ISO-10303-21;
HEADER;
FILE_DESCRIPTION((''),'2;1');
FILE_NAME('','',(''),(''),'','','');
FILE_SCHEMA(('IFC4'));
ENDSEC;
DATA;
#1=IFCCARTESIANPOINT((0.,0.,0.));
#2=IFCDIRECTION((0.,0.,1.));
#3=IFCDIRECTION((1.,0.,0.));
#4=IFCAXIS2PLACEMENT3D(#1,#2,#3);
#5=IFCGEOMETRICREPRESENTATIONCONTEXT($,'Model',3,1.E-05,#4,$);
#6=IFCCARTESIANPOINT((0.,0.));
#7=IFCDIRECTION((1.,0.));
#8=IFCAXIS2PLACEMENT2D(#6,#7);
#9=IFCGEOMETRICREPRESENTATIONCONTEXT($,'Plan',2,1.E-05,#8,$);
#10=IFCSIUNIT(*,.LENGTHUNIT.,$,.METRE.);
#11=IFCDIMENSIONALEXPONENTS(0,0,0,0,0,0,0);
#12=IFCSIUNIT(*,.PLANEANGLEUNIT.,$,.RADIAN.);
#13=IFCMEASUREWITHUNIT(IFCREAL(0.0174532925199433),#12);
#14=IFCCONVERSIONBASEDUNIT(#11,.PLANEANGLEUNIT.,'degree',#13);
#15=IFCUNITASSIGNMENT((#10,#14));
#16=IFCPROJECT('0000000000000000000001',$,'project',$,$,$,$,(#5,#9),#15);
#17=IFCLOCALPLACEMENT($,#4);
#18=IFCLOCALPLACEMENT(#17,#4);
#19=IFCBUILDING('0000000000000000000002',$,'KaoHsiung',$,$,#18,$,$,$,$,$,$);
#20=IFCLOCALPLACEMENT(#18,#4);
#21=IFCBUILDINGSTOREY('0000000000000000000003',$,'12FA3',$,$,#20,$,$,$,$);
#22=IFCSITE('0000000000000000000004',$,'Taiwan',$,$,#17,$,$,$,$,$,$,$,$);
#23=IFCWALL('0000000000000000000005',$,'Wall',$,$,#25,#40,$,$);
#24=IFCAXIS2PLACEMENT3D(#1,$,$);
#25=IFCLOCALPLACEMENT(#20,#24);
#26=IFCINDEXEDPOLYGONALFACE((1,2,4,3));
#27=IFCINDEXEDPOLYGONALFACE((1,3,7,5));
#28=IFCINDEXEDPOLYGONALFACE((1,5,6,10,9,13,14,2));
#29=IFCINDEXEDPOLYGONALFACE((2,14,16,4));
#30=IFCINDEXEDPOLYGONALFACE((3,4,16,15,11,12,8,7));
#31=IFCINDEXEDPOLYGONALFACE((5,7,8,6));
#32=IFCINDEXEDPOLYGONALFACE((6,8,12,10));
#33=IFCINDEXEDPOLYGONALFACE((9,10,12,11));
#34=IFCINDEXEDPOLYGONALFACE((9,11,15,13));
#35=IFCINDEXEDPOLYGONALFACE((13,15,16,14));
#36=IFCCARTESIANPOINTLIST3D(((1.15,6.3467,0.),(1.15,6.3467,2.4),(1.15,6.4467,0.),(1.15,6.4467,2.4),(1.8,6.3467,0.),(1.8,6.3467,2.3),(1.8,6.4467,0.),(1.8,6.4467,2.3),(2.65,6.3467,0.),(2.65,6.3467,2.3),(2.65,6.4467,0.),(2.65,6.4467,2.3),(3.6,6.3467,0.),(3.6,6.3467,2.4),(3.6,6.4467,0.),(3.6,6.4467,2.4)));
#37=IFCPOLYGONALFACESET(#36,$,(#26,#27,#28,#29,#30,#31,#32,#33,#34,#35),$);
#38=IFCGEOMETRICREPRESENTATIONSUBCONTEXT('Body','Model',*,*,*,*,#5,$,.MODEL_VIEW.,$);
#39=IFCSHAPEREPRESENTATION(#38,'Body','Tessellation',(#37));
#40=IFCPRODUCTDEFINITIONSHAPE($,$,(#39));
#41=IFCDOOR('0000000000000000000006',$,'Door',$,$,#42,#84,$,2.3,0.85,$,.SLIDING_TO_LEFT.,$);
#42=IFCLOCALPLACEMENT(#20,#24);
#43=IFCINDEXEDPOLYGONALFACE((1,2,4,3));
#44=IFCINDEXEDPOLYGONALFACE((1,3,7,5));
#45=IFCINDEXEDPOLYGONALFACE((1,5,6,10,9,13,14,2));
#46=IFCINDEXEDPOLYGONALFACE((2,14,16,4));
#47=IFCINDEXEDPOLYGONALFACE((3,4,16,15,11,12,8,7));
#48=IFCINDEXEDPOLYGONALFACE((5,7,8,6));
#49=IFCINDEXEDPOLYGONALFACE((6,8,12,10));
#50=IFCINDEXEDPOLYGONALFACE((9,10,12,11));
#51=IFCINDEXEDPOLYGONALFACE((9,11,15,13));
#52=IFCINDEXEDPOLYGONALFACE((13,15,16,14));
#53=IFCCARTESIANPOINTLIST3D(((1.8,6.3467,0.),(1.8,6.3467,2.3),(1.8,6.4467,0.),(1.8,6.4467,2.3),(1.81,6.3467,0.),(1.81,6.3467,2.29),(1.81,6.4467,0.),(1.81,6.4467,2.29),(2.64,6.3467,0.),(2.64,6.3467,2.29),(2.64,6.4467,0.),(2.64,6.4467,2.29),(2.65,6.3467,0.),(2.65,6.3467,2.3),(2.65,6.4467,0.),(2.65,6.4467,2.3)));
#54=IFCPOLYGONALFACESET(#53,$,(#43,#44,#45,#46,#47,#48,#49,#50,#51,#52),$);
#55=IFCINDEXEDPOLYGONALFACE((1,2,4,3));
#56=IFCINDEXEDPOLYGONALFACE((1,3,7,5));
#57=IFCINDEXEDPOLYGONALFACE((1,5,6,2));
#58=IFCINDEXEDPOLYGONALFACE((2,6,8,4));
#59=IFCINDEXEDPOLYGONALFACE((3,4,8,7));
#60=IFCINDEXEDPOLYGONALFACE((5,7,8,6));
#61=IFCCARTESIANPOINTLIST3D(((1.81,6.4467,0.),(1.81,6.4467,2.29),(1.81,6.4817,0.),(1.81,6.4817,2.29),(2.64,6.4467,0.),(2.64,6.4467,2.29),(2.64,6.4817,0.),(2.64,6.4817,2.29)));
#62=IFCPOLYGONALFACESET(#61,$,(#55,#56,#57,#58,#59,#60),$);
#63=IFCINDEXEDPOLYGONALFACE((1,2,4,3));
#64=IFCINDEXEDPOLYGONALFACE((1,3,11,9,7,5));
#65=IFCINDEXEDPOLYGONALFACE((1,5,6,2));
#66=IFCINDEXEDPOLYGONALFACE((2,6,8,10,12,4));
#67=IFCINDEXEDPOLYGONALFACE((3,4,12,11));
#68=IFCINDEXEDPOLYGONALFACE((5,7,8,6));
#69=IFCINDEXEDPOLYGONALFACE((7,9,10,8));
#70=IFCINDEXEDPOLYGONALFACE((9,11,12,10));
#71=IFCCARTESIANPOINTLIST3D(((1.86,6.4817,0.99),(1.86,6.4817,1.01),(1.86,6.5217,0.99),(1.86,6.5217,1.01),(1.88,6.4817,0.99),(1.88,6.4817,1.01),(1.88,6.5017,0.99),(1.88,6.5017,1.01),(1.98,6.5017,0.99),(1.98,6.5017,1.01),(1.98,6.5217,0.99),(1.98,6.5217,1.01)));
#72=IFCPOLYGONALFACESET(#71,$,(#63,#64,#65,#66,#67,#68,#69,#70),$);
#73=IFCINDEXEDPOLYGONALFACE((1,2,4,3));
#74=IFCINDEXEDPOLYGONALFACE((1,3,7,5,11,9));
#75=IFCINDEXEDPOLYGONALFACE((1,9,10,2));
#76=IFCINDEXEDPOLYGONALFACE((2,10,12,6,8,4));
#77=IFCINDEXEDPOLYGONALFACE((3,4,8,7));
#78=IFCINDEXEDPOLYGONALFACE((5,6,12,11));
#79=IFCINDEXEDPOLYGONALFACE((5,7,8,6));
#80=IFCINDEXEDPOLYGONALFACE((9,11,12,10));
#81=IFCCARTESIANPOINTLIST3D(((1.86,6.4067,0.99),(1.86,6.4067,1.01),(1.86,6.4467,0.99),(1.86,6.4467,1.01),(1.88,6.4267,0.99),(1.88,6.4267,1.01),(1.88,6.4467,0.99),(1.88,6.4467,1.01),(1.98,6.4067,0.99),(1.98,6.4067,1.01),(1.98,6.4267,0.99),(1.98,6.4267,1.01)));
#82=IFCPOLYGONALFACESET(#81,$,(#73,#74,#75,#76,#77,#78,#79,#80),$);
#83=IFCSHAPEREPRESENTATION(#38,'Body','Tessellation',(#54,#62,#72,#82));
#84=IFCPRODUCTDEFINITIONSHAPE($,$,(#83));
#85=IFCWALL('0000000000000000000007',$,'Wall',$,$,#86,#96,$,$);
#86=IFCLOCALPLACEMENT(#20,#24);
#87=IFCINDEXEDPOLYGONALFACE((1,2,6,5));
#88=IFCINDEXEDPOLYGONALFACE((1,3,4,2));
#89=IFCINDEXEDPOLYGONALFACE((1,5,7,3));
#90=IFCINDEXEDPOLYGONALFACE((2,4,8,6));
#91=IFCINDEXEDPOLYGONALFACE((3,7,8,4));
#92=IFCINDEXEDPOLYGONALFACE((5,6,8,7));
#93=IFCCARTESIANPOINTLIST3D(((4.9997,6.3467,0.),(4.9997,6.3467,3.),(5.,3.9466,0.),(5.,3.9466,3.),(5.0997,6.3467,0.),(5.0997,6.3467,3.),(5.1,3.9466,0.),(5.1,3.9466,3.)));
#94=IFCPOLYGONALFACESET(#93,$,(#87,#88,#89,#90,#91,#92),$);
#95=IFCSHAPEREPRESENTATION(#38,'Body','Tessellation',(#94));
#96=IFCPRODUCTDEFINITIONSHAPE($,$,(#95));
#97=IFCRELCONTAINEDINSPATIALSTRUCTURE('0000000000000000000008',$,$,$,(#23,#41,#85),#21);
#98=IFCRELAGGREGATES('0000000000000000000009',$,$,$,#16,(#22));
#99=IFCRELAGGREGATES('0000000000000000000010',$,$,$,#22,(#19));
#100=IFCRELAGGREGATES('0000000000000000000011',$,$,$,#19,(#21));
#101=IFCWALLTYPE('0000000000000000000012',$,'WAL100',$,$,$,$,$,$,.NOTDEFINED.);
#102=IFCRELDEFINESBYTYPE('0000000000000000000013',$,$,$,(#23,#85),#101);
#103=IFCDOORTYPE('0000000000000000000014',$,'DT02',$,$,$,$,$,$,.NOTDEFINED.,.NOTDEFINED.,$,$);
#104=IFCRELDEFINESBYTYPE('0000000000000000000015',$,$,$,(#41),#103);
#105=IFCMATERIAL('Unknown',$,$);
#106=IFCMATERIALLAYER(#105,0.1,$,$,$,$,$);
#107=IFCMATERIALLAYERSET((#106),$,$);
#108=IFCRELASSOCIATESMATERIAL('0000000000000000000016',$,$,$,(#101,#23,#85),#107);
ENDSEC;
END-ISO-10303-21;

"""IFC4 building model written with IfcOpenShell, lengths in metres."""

from ifc_helpers import new_model, entity, si_unit, converted_unit, frame, origin_with_axes, origin_2d_with_axis, place, context, subcontext, project, spatial, line, indexed_curve, outline, extrude, shape, source, transform, mapped, material, layer, layer_set, layer_usage, type_object, type_shapes, element, fill, save


model = new_model("IFC4")

# Units and contexts
model_context = context("Model", 3, precision=1e-05, world=origin_with_axes())
plan_context = context("Plan", 2, precision=1e-05, world=origin_2d_with_axis())
body_context_1 = subcontext(model_context, "Body", "Model", "MODEL_VIEW")
body_context_2 = subcontext(plan_context, "Body", "Plan", "PLAN_VIEW")
ifc_project = project(units=[si_unit("LENGTHUNIT", "METRE"), converted_unit("PLANEANGLEUNIT", "degree", entity("IfcReal", 0.0174532925199433), si_unit("PLANEANGLEUNIT", "RADIAN"), dimensions=[0, 0, 0, 0, 0, 0, 0])], contexts=[model_context, plan_context])

# Site, building, storey
site_placement = place(None, origin_with_axes())
site = spatial("IfcSite", under=ifc_project, at=site_placement, Name="Taiwan")
building_placement = place(site_placement, origin_with_axes())
building = spatial("IfcBuilding", under=site, at=building_placement, Name="KaoHsiung")
storey_placement = place(building_placement, origin_with_axes())
storey = spatial("IfcBuildingStorey", under=building, at=storey_placement, Name="12FA3")

# Shared definitions
ifc_material = material(Name="Unknown")

# Shared definitions
ifc_layer_1 = layer(ifc_material, 0.1)
ifc_layer_set_1 = layer_set([ifc_layer_1])
wall_type_1 = type_object("IfcWallType", Name="WAL100", PredefinedType="NOTDEFINED", material=ifc_layer_set_1)

# Wall, opening, door
ifc_layer_usage_1 = layer_usage(ifc_layer_set_1, "AXIS2", "POSITIVE", 0.0)
wall_1_placement = place(storey_placement, frame((3.6, 6.4467, 0.0), z_axis=(0.0, 0.0, 1.0), x_axis=(-1.0, 0.0, 0.0)))
wall_1 = element("IfcWall", 1, at=wall_1_placement, inside=storey, type_object=wall_type_1, material=ifc_layer_usage_1, Name="Wall", context=body_context_1, shape_type="SweptSolid", body=[
    extrude(outline(indexed_curve([(0.0, 0.0), (0.0, 0.1), (2.45, 0.1), (2.45, 0.0)], segments=[line(1, 2, 3, 4, 1)])), origin_with_axes(), (0.0, 0.0, 1.0), 2.4),
])
shared_shape_1 = source(origin_with_axes(), body_context_1, "Body", "SweptSolid", [
    extrude(outline(indexed_curve([(0.0, 0.0), (0.85, 0.0), (0.85, 2.3), (0.0, 2.3)], segments=[line(1, 2, 3, 4, 1)])), frame((0.0, -0.6, 0.0), z_axis=(0.0, -1.0, 0.0), x_axis=(1.0, 0.0, 0.0)), (0.0, 0.0, -1.0), 1.2),
])
opening_1_placement = place(wall_1_placement, frame((0.95, 0.0, 0.0), z_axis=(0.0, 0.0, 1.0), x_axis=(1.0, 0.0, 0.0)))
opening_1 = element("IfcOpeningElement", 2, at=opening_1_placement, cuts=wall_1, PredefinedType="OPENING", context=body_context_1, shape_type="MappedRepresentation", body=[
    mapped(shared_shape_1, transform((0.0, 0.0, 0.0), x_axis=(1.0, 0.0, 0.0), y_axis=(0.0, 1.0, 0.0), z_axis=(0.0, 0.0, 1.0), scale=1.0)),
])
door_type_1 = type_object("IfcDoorType", Name="DT02", OperationType="NOTDEFINED", PredefinedType="NOTDEFINED")
shared_shape_2 = source(origin_with_axes(), body_context_1, "Body", "SweptSolid", [
    extrude(outline(indexed_curve([(0.0, 0.0), (0.0, 2.3), (0.85, 2.3), (0.85, 0.0), (0.84, 0.0), (0.84, 2.29), (0.01, 2.29), (0.01, 0.0)], segments=[line(1, 2, 3, 4, 5, 6, 7, 8, 1)])), frame((0.0, 0.0, 0.0), z_axis=(0.0, -1.0, 0.0), x_axis=(1.0, 0.0, 0.0)), (0.0, 0.0, -1.0), 0.1),
    extrude(outline(indexed_curve([(0.0, 0.0), (0.83, 0.0), (0.83, 0.035), (0.0, 0.035)], segments=[line(1, 2, 3, 4, 1)])), frame((0.01, -0.035, 0.0), z_axis=(0.0, 0.0, 1.0), x_axis=(1.0, 0.0, 0.0)), (0.0, 0.0, 1.0), 2.29),
    extrude(outline(indexed_curve([(0.0, 0.0), (0.0, -0.04), (-0.12, -0.04), (-0.12, -0.02), (-0.02, -0.02), (-0.02, 0.0)], segments=[line(1, 2, 3, 4, 5, 6, 1)])), frame((0.79, -0.035, 0.99), z_axis=(0.0, 0.0, 1.0), x_axis=(1.0, 0.0, 0.0)), (0.0, 0.0, 1.0), 0.02),
    extrude(outline(indexed_curve([(0.0, 0.0), (0.0, 0.04), (-0.12, 0.04), (-0.12, 0.02), (-0.02, 0.02), (-0.02, 0.0)], segments=[line(1, 2, 3, 4, 5, 6, 1)])), frame((0.79, 0.0, 0.99), z_axis=(0.0, 0.0, 1.0), x_axis=(1.0, 0.0, 0.0)), (0.0, 0.0, 1.0), 0.02),
])
shared_shape_3 = source(origin_with_axes(), body_context_2, "Body", "Curve2D", [
    entity("IfcIndexedPolyCurve", entity("IfcCartesianPointList2D", [[0.0, 0.0], [0.01, 0.0], [0.01, 0.1], [0.0, 0.1]]), [entity("IfcLineIndex", [1, 2, 3, 4, 1])]),
    entity("IfcIndexedPolyCurve", entity("IfcCartesianPointList2D", [[0.85, 0.0], [0.84, 0.0], [0.84, 0.1], [0.85, 0.1]]), [entity("IfcLineIndex", [1, 2, 3, 4, 1])]),
    entity("IfcIndexedPolyCurve", entity("IfcCartesianPointList2D", [[-0.405, -0.035], [0.425, -0.035], [0.425, 0.0], [-0.405, 0.0]]), [entity("IfcLineIndex", [1, 2, 3, 4, 1])]),
])
type_shapes(door_type_1, [shared_shape_2, shared_shape_3])
door_1_placement = place(opening_1_placement, frame((0.0, 0.0, 0.0), z_axis=(0.0, 0.0, 1.0), x_axis=(1.0, 0.0, 0.0)))
door_1 = element("IfcDoor", 3, at=door_1_placement, inside=storey, type_object=door_type_1, Name="Door", OperationType="SLIDING_TO_LEFT", OverallHeight=2.3, OverallWidth=0.85, shapes=[
    shape(body_context_1, "Body", "MappedRepresentation", [mapped(shared_shape_2, transform((0.0, 0.0, 0.0), x_axis=(1.0, 0.0, 0.0), y_axis=(0.0, 1.0, 0.0), z_axis=(0.0, 0.0, 1.0), scale=1.0))]),
    shape(body_context_2, "Body", "MappedRepresentation", [mapped(shared_shape_3, transform((0.0, 0.0, 0.0), x_axis=(1.0, 0.0, 0.0), y_axis=(0.0, 1.0, 0.0), z_axis=(0.0, 0.0, 1.0), scale=1.0))]),
])
fill(opening_1, door_1)

# Wall
ifc_layer_usage_2 = layer_usage(ifc_layer_set_1, "AXIS2", "POSITIVE", 0.0)
wall_2_placement = place(storey_placement, frame((4.9997, 6.3467, 0.0), z_axis=(0.0, 0.0, 1.0), x_axis=(0.000135, -1.0, 0.0)))
element("IfcWall", 4, at=wall_2_placement, inside=storey, type_object=wall_type_1, material=ifc_layer_usage_2, Name="Wall", context=body_context_1, shape_type="SweptSolid", body=[
    extrude(outline(indexed_curve([(0.0, 0.0), (0.0, 0.1), (2.4001, 0.1), (2.4001, 0.0)], segments=[line(1, 2, 3, 4, 1)])), origin_with_axes(), (0.0, 0.0, 1.0), 3.0),
])

save(model, "model.ifc")
